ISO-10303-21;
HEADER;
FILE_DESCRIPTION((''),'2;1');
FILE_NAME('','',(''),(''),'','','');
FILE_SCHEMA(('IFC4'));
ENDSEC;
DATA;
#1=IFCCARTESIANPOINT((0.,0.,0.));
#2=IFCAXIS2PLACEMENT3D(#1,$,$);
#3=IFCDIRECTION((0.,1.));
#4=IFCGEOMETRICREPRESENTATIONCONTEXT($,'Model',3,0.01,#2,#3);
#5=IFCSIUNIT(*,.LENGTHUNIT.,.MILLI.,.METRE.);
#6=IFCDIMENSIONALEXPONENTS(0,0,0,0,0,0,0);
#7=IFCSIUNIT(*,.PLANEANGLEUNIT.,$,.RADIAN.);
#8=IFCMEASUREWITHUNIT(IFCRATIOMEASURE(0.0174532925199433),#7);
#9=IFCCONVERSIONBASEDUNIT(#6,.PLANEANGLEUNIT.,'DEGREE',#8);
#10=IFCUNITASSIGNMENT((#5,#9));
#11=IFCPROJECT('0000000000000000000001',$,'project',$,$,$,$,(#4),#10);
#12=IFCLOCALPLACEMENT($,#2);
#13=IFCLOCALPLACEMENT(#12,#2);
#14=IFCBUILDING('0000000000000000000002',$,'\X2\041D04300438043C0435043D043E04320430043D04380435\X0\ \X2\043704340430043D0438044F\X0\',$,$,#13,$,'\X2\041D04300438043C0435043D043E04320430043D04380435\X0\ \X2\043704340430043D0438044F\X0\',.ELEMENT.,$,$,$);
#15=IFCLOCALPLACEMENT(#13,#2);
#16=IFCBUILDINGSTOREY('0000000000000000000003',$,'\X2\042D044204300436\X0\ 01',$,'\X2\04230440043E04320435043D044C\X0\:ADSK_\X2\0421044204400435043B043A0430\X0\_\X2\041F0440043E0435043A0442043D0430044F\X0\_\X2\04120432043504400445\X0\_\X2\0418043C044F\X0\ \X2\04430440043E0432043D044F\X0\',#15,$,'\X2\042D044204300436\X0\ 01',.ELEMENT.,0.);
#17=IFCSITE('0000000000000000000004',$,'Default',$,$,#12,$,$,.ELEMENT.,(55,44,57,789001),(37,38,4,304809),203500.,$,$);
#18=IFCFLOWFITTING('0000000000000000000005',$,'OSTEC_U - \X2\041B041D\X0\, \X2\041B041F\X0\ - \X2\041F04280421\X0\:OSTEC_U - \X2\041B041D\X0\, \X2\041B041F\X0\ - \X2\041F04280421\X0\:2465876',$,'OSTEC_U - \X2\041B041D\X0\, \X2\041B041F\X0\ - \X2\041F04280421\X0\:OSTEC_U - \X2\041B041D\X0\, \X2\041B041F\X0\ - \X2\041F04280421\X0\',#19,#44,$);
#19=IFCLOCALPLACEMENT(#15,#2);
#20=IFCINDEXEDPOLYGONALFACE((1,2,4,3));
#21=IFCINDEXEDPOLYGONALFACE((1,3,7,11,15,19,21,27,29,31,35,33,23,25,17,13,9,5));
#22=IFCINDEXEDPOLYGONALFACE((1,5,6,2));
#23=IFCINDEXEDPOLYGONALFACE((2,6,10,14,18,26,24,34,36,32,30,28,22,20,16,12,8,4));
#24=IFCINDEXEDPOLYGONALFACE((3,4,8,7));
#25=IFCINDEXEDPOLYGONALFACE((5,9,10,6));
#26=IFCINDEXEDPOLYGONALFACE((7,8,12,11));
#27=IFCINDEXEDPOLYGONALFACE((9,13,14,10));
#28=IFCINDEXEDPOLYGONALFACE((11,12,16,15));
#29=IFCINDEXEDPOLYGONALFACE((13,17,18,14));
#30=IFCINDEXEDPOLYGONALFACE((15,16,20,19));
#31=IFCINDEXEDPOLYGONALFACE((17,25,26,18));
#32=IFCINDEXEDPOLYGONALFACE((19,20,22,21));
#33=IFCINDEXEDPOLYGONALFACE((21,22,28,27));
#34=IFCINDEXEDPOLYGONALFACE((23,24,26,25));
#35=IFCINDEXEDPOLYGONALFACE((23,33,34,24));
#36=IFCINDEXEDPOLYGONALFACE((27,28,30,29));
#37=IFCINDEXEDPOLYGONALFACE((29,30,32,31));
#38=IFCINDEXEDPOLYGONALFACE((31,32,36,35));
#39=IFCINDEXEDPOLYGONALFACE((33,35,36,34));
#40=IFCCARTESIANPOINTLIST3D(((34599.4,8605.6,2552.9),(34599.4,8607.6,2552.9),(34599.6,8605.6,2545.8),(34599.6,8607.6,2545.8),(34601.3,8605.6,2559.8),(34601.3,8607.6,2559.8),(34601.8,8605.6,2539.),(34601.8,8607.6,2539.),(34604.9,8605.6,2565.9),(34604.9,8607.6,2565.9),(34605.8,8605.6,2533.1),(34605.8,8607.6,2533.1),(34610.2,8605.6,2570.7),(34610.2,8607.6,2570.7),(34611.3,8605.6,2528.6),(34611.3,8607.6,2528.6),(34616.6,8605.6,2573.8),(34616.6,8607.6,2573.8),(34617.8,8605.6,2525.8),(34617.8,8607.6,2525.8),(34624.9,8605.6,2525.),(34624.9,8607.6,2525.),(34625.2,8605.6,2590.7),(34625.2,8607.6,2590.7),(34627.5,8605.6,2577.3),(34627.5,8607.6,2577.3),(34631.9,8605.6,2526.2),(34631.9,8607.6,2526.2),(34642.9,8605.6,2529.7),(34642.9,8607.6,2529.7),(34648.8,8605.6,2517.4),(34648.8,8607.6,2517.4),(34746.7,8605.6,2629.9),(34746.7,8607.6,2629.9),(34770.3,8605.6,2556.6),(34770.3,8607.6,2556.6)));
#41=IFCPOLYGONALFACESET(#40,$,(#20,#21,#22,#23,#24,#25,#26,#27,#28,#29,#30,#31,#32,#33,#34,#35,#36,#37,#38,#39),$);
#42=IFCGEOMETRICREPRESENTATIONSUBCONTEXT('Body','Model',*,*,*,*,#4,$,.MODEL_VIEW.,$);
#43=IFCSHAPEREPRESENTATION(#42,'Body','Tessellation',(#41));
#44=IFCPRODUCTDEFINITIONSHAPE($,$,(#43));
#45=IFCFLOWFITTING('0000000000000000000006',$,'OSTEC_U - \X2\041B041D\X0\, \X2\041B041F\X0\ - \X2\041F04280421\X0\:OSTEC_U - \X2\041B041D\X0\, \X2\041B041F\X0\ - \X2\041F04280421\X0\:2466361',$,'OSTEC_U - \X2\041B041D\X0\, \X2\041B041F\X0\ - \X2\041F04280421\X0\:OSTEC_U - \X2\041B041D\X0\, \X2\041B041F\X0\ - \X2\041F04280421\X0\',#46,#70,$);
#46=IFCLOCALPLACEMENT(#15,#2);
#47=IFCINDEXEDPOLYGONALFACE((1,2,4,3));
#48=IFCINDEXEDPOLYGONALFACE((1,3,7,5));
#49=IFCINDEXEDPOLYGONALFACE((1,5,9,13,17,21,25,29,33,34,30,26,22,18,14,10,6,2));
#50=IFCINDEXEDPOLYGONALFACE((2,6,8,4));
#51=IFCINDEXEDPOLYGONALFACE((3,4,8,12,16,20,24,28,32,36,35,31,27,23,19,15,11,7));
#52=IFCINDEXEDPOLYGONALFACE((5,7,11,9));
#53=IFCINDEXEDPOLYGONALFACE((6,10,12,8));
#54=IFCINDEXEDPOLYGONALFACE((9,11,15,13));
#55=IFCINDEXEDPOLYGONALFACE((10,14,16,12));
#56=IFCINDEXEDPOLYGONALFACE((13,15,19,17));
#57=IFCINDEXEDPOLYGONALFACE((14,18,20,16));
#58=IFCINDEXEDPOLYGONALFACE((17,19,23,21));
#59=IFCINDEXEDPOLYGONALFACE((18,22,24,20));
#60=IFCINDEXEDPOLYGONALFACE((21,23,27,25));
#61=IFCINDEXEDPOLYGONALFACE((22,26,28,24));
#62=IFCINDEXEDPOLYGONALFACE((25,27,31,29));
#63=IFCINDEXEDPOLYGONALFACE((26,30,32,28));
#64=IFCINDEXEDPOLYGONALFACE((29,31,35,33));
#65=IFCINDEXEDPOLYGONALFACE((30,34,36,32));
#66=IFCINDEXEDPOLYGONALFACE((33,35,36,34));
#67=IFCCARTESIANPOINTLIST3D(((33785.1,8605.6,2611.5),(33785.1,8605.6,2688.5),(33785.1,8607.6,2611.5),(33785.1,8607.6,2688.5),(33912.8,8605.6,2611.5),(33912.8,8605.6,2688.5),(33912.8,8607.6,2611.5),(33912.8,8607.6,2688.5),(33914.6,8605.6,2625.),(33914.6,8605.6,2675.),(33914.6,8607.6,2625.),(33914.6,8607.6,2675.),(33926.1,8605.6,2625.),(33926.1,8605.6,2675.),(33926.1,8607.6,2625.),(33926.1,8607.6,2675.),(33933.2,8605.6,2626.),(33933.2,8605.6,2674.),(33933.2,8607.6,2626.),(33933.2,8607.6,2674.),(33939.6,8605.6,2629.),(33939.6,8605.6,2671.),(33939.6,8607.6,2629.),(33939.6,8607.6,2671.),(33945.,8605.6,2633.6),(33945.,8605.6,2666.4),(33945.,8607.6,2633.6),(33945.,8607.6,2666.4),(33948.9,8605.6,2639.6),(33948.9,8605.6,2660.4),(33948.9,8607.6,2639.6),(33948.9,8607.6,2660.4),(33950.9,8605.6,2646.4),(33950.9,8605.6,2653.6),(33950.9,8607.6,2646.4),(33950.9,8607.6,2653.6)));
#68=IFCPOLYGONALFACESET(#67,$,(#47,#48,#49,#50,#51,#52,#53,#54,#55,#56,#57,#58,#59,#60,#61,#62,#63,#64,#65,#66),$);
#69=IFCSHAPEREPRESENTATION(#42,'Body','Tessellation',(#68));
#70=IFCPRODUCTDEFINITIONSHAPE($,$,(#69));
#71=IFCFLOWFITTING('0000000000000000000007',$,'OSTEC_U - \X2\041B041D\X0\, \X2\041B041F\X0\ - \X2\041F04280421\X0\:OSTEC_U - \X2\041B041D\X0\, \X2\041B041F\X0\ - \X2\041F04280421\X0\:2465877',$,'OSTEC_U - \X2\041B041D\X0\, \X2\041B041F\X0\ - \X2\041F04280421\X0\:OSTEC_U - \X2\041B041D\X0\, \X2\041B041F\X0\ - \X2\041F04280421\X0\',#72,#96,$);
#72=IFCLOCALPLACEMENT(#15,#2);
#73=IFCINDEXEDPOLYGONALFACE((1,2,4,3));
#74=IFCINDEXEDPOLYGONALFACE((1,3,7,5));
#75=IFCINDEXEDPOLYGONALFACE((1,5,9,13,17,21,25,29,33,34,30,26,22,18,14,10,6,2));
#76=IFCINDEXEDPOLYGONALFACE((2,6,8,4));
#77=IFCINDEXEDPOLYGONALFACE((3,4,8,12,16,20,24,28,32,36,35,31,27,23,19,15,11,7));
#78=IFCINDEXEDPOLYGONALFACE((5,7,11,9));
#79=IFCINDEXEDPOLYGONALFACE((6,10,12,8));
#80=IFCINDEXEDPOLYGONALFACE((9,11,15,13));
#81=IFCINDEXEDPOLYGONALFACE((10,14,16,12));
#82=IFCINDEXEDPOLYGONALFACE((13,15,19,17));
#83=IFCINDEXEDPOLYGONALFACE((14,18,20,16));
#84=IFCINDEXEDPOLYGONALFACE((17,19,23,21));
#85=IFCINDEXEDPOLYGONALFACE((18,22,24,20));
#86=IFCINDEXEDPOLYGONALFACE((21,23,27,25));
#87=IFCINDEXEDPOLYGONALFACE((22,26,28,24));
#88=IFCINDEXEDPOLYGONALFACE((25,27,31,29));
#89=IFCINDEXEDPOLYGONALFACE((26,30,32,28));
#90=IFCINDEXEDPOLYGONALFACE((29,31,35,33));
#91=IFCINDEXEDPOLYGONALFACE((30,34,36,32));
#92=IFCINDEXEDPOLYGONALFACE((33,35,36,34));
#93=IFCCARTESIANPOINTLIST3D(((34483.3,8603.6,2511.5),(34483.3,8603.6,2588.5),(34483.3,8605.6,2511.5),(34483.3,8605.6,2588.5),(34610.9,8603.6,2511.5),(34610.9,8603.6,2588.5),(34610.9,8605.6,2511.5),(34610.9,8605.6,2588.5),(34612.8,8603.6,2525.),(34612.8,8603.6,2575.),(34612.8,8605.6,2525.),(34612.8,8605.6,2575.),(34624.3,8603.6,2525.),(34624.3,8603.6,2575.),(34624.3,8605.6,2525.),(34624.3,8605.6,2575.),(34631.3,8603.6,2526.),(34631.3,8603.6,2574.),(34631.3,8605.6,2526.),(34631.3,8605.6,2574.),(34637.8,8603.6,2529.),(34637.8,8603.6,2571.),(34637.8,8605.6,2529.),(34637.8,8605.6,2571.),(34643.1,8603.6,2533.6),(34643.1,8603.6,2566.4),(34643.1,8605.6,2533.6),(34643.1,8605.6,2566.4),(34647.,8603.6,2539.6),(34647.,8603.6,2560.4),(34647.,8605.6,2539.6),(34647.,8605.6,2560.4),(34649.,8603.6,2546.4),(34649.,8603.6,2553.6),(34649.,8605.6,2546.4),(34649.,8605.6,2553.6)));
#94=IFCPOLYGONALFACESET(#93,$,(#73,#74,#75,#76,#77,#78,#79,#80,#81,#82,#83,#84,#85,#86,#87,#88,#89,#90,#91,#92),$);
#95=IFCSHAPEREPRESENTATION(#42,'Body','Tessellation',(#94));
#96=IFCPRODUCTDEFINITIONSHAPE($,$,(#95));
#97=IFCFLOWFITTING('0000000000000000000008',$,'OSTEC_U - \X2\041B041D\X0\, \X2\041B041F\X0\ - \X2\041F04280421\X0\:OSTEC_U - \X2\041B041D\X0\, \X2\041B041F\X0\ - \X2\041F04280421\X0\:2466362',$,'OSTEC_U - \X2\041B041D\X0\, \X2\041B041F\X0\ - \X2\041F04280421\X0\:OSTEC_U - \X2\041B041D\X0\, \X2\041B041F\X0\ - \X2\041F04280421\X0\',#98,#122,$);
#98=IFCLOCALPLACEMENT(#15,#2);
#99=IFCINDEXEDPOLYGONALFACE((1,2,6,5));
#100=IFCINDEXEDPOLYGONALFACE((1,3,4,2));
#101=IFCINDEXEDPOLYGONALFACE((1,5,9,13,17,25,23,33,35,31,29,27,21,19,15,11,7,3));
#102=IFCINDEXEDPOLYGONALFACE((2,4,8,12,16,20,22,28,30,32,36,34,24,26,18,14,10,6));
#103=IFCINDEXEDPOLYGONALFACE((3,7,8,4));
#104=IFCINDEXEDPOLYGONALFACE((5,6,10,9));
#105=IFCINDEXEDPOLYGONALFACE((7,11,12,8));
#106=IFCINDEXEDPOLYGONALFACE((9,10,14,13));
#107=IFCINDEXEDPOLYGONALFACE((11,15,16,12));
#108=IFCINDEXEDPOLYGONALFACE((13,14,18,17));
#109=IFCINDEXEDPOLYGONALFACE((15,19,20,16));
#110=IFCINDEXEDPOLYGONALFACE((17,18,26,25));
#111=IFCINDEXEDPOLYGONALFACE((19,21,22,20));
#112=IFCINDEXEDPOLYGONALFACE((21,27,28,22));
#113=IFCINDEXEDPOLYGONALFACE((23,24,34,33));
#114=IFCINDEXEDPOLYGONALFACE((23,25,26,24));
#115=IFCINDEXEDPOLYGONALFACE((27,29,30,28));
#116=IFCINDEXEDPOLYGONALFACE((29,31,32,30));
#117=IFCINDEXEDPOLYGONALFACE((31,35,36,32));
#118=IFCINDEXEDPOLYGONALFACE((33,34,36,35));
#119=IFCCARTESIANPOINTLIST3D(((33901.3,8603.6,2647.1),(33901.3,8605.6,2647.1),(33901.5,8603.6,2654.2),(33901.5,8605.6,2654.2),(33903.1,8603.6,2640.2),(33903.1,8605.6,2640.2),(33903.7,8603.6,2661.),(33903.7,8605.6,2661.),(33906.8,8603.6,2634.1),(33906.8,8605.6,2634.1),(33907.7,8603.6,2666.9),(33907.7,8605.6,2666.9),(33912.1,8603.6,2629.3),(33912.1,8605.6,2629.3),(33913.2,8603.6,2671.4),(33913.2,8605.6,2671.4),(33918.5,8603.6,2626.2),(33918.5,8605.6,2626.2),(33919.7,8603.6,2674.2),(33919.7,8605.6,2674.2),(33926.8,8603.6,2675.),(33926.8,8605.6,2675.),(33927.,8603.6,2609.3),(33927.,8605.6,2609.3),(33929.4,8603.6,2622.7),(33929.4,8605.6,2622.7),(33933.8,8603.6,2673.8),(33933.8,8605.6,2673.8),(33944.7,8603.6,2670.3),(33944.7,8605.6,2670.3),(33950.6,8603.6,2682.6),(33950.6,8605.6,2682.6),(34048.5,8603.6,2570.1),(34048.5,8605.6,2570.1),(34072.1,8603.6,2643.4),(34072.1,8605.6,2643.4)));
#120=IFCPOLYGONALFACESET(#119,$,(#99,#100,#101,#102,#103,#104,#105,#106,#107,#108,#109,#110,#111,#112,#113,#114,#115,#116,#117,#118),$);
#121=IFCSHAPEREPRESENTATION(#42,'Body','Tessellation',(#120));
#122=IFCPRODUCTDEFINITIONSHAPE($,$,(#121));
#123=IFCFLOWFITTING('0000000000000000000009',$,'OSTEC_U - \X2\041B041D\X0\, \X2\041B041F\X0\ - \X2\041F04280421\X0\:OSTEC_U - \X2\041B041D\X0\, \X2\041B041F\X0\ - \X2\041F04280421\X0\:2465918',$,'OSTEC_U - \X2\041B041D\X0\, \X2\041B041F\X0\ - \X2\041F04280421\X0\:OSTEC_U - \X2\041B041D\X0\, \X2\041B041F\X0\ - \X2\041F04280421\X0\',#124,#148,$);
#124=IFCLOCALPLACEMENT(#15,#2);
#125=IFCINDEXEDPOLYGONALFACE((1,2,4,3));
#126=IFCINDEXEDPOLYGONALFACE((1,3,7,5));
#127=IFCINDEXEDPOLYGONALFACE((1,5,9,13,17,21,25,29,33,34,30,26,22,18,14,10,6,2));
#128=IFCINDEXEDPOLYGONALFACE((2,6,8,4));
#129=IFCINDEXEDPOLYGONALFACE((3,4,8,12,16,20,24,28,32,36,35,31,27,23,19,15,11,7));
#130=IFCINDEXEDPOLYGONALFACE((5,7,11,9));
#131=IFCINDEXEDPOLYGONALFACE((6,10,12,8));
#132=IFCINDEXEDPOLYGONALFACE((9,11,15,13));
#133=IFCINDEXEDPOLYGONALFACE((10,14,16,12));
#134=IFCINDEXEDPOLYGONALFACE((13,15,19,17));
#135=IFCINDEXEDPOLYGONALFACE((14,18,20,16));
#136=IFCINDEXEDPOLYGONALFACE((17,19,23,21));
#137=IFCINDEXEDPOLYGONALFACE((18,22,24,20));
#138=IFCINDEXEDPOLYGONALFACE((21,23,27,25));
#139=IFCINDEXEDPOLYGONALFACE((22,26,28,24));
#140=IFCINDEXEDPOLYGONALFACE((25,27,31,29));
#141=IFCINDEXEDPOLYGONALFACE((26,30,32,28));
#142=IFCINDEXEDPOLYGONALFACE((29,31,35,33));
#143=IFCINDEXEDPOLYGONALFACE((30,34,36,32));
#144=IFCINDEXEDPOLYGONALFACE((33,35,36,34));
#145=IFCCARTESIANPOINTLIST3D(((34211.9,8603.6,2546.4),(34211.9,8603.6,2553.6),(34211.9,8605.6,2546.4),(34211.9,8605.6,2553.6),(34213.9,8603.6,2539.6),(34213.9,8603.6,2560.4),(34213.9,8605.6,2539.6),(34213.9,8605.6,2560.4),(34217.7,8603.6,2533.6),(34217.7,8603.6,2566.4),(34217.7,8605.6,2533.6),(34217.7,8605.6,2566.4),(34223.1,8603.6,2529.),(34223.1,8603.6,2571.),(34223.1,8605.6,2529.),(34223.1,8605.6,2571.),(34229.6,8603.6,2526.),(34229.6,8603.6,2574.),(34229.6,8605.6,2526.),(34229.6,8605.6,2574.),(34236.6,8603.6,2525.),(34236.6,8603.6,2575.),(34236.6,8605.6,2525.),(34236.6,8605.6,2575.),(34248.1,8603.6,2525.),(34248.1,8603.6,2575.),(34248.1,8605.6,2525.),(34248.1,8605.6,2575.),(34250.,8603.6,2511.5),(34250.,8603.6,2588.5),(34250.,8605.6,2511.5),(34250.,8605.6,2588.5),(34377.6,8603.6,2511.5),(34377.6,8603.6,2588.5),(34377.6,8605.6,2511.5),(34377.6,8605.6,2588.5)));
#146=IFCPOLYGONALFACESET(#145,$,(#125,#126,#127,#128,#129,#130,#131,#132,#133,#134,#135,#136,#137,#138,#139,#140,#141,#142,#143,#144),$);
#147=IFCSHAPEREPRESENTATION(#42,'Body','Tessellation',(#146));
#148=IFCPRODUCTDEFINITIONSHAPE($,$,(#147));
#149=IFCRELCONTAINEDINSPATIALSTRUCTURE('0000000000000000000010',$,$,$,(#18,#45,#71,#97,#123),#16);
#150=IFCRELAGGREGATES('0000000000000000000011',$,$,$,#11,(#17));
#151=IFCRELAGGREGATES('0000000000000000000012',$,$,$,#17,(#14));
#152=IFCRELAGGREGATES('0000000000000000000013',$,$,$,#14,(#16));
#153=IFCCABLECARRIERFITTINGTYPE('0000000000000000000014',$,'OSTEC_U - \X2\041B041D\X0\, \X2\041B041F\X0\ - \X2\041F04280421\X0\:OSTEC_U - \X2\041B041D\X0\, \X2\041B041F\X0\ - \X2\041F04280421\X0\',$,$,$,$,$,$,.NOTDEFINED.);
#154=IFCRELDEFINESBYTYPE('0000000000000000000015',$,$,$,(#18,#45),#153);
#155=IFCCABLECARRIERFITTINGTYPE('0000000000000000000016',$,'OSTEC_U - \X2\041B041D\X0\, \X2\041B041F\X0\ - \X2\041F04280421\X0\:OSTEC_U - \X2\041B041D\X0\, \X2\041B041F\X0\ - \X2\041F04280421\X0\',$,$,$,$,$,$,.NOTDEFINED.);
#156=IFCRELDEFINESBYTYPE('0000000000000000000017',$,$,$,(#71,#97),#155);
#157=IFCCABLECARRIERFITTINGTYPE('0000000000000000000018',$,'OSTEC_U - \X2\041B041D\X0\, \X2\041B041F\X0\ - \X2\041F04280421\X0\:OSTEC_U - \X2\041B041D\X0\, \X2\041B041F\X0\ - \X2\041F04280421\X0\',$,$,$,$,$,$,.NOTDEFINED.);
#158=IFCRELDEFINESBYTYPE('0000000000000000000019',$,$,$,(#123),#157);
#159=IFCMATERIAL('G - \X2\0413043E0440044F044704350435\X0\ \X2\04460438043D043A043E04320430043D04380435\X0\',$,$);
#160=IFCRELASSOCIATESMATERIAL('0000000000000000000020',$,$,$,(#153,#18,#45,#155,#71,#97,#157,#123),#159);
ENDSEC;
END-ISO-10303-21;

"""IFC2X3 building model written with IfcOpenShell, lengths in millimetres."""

from ifc_helpers import new_model, entity, si_unit, converted_unit, direction, frame, frame_2d, origin, place, context, subcontext, project, spatial, polyline, circle_curve, parameter, trimmed, segment, composite_curve, outline, extrude, source, transform, mapped, material, type_object, type_shapes, element, save


model = new_model("IFC2X3")

# Units and contexts
model_context = context("Model", 3, precision=0.01, world=origin(), true_north=direction((0.0, 1.0)))
body_context = subcontext(model_context, "Body", "Model", "MODEL_VIEW")
ifc_project = project(units=[si_unit("LENGTHUNIT", "METRE", prefix="MILLI"), converted_unit("PLANEANGLEUNIT", "DEGREE", entity("IfcRatioMeasure", 0.0174532925199433), si_unit("PLANEANGLEUNIT", "RADIAN"), dimensions=[0, 0, 0, 0, 0, 0, 0])], contexts=[model_context])

# Site, building, storey
site_placement = place(None, frame((0.0, 0.0, 0.0)))
site = spatial("IfcSite", under=ifc_project, at=site_placement, Name="Default", CompositionType="ELEMENT", RefLatitude=(55, 44, 57, 789001), RefLongitude=(37, 38, 4, 304809), RefElevation=203500.0)
building_placement = place(site_placement, origin())
building = spatial("IfcBuilding", under=site, at=building_placement, Name="Наименование здания", LongName="Наименование здания", CompositionType="ELEMENT")
storey_placement = place(building_placement, origin())
storey = spatial("IfcBuildingStorey", under=building, at=storey_placement, Name="Этаж 01", ObjectType="Уровень:ADSK_Стрелка_Проектная_Вверх_Имя уровня", LongName="Этаж 01", CompositionType="ELEMENT", Elevation=0.0)

# Flow fittings
ifc_material = material(Name="G - Горячее цинкование")
cable_carrier_fitting_type_1 = type_object("IfcCableCarrierFittingType", Name="OSTEC_U - ЛН, ЛП - ПШС:OSTEC_U - ЛН, ЛП - ПШС", PredefinedType="NOTDEFINED", material=ifc_material)
shared_shape_1 = source(origin(), body_context, "Body", "SweptSolid", [
    extrude(outline(composite_curve([segment(trimmed(circle_curve(frame_2d((-41.5, 0.0), x_axis=(1.0, 0.0)), 25.0), [parameter(90.0)], [parameter(270.0)], True, "PARAMETER"), True, "CONTINUOUS"), segment(polyline([(-41.5, -25.0), (-30.0, -25.0)]), True, "CONTINUOUS"), segment(polyline([(-30.0, -25.0), (-28.1, -38.5)]), True, "CONTINUOUS"), segment(polyline([(-28.1, -38.5), (99.5, -38.5)]), True, "CONTINUOUS"), segment(polyline([(99.5, -38.5), (99.5, 38.5)]), True, "CONTINUOUS"), segment(polyline([(99.5, 38.5), (-28.1, 38.5)]), True, "CONTINUOUS"), segment(polyline([(-28.1, 38.5), (-30.0, 25.0)]), True, "CONTINUOUS"), segment(polyline([(-30.0, 25.0), (-41.5, 25.0)]), True, "CONTINUOUS")], self_intersect=False)), frame((41.5, 0.0, 0.0)), (0.0, 0.0, 1.0), 2.0),
])
type_shapes(cable_carrier_fitting_type_1, [shared_shape_1])
for number, where, z_axis, x_axis, name in (
    (1, (34624.3, 8605.6, 2550.0), (0.0, 1.0, 0.0), (0.951851, 0.0, 0.30656), "OSTEC_U - ЛН, ЛП - ПШС:OSTEC_U - ЛН, ЛП - ПШС:2465876"),
    (2, (33926.1, 8605.6, 2650.0), (0.0, 1.0, 0.0), (-1.0, 0.0, 0.0), "OSTEC_U - ЛН, ЛП - ПШС:OSTEC_U - ЛН, ЛП - ПШС:2466361"),
):
    element("IfcFlowFitting", number, at=place(storey_placement, frame(where, z_axis=z_axis, x_axis=x_axis)), inside=storey, type_object=cable_carrier_fitting_type_1, material=ifc_material, Name=name, ObjectType="OSTEC_U - ЛН, ЛП - ПШС:OSTEC_U - ЛН, ЛП - ПШС", context=body_context, shape_type="MappedRepresentation", body=[
        mapped(shared_shape_1, transform((0.0, 0.0, 0.0), scale=1.0)),
    ])
cable_carrier_fitting_type_2 = type_object("IfcCableCarrierFittingType", Name="OSTEC_U - ЛН, ЛП - ПШС:OSTEC_U - ЛН, ЛП - ПШС", PredefinedType="NOTDEFINED", material=ifc_material)
shared_shape_2 = source(origin(), body_context, "Body", "SweptSolid", [
    extrude(outline(composite_curve([segment(trimmed(circle_curve(frame_2d((-41.5, 0.0), x_axis=(1.0, 0.0)), 25.0), [parameter(90.0)], [parameter(270.0)], True, "PARAMETER"), True, "CONTINUOUS"), segment(polyline([(-41.5, -25.0), (-30.0, -25.0)]), True, "CONTINUOUS"), segment(polyline([(-30.0, -25.0), (-28.1, -38.5)]), True, "CONTINUOUS"), segment(polyline([(-28.1, -38.5), (99.5, -38.5)]), True, "CONTINUOUS"), segment(polyline([(99.5, -38.5), (99.5, 38.5)]), True, "CONTINUOUS"), segment(polyline([(99.5, 38.5), (-28.1, 38.5)]), True, "CONTINUOUS"), segment(polyline([(-28.1, 38.5), (-30.0, 25.0)]), True, "CONTINUOUS"), segment(polyline([(-30.0, 25.0), (-41.5, 25.0)]), True, "CONTINUOUS")], self_intersect=False)), frame((41.5, 0.0, 0.0), z_axis=(0.0, 0.0, -1.0), x_axis=(1.0, 0.0, 0.0)), (0.0, 0.0, -1.0), 2.0),
])
type_shapes(cable_carrier_fitting_type_2, [shared_shape_2])
for number, where, z_axis, x_axis, name in (
    (3, (34624.3, 8603.6, 2550.0), (0.0, 1.0, 0.0), (-1.0, 0.0, 0.0), "OSTEC_U - ЛН, ЛП - ПШС:OSTEC_U - ЛН, ЛП - ПШС:2465877"),
    (4, (33926.1, 8603.6, 2650.0), (0.0, 1.0, 0.0), (0.951851, 0.0, -0.30656), "OSTEC_U - ЛН, ЛП - ПШС:OSTEC_U - ЛН, ЛП - ПШС:2466362"),
):
    element("IfcFlowFitting", number, at=place(storey_placement, frame(where, z_axis=z_axis, x_axis=x_axis)), inside=storey, type_object=cable_carrier_fitting_type_2, material=ifc_material, Name=name, ObjectType="OSTEC_U - ЛН, ЛП - ПШС:OSTEC_U - ЛН, ЛП - ПШС", context=body_context, shape_type="MappedRepresentation", body=[
        mapped(shared_shape_2, transform((0.0, 0.0, 0.0), scale=1.0)),
    ])
cable_carrier_fitting_type_3 = type_object("IfcCableCarrierFittingType", Name="OSTEC_U - ЛН, ЛП - ПШС:OSTEC_U - ЛН, ЛП - ПШС", PredefinedType="NOTDEFINED", material=ifc_material)
shared_shape_3 = source(origin(), body_context, "Body", "SweptSolid", [
    extrude(outline(composite_curve([segment(trimmed(circle_curve(frame_2d((-41.5, 0.0), x_axis=(1.0, 0.0)), 25.0), [parameter(90.0)], [parameter(270.0)], True, "PARAMETER"), True, "CONTINUOUS"), segment(polyline([(-41.5, -25.0), (-30.0, -25.0)]), True, "CONTINUOUS"), segment(polyline([(-30.0, -25.0), (-28.1, -38.5)]), True, "CONTINUOUS"), segment(polyline([(-28.1, -38.5), (99.5, -38.5)]), True, "CONTINUOUS"), segment(polyline([(99.5, -38.5), (99.5, 38.5)]), True, "CONTINUOUS"), segment(polyline([(99.5, 38.5), (-28.1, 38.5)]), True, "CONTINUOUS"), segment(polyline([(-28.1, 38.5), (-30.0, 25.0)]), True, "CONTINUOUS"), segment(polyline([(-30.0, 25.0), (-41.5, 25.0)]), True, "CONTINUOUS")], self_intersect=False)), frame((41.5, 0.0, 0.0)), (0.0, 0.0, 1.0), 2.0),
])
type_shapes(cable_carrier_fitting_type_3, [shared_shape_3])
flow_fitting_1_placement = place(storey_placement, frame((34236.6, 8603.6, 2550.0), z_axis=(0.0, 1.0, 0.0), x_axis=(1.0, 0.0, 0.0)))
element("IfcFlowFitting", 5, at=flow_fitting_1_placement, inside=storey, type_object=cable_carrier_fitting_type_3, material=ifc_material, Name="OSTEC_U - ЛН, ЛП - ПШС:OSTEC_U - ЛН, ЛП - ПШС:2465918", ObjectType="OSTEC_U - ЛН, ЛП - ПШС:OSTEC_U - ЛН, ЛП - ПШС", context=body_context, shape_type="MappedRepresentation", body=[
    mapped(shared_shape_3, transform((0.0, 0.0, 0.0), scale=1.0)),
])

save(model, "model.ifc")
